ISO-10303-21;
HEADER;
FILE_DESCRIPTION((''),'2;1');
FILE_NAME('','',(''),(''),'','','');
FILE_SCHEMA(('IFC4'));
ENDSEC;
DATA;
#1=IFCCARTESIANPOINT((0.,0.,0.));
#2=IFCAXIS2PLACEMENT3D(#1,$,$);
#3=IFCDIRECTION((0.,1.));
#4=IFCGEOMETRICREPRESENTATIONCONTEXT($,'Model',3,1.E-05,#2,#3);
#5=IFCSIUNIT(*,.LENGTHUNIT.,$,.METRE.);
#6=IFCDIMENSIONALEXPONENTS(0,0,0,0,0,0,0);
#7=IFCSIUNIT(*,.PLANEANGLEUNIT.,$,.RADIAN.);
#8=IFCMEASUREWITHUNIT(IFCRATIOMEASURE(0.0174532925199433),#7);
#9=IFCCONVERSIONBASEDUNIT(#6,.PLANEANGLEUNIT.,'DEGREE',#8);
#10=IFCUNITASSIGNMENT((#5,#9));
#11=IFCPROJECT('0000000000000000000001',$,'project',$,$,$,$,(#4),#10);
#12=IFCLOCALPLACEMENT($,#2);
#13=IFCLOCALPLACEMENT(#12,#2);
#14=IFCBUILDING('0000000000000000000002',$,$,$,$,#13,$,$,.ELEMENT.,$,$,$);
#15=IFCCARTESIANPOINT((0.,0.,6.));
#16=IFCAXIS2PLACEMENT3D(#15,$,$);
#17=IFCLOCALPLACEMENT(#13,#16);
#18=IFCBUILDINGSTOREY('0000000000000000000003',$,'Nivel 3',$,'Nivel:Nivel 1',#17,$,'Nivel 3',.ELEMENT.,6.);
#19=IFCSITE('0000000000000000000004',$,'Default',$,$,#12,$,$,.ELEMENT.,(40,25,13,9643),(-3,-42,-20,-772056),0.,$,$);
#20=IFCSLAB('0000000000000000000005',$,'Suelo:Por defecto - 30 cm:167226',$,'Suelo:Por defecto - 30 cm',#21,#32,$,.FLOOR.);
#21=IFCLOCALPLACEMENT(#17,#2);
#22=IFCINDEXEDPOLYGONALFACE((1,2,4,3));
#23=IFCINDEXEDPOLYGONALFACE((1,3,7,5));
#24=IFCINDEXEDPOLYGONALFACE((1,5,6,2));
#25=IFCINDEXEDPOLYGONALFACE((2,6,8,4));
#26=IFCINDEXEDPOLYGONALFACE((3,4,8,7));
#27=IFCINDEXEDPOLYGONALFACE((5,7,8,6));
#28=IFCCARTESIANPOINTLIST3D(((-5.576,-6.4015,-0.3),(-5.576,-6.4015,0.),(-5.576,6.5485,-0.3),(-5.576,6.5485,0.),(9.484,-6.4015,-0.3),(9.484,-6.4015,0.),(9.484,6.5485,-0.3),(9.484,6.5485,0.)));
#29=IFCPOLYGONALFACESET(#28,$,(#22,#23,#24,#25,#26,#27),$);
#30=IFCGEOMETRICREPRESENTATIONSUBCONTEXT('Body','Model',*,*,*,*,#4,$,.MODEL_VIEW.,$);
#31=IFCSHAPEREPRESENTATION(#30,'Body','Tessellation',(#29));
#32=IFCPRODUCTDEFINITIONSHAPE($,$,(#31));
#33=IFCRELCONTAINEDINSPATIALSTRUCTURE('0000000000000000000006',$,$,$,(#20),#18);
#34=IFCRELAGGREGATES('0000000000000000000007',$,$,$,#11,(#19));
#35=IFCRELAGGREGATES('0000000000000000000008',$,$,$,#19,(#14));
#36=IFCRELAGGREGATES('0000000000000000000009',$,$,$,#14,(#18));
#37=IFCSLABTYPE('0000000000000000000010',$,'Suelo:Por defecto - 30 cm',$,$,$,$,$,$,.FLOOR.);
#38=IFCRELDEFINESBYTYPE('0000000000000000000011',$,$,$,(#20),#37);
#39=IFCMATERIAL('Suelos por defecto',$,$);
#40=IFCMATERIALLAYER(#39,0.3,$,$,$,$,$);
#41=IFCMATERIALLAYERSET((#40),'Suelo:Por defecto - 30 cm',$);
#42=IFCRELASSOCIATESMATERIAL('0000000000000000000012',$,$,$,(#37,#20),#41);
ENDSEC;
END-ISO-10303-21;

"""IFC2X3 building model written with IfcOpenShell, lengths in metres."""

from ifc_helpers import new_model, entity, si_unit, converted_unit, direction, frame, origin, origin_2d_with_axis, place, context, subcontext, project, spatial, rectangle, extrude, material, layer, layer_set, layer_usage, type_object, element, save


model = new_model("IFC2X3")

# Units and contexts
model_context = context("Model", 3, precision=1e-05, world=origin(), true_north=direction((0.0, 1.0)))
body_context = subcontext(model_context, "Body", "Model", "MODEL_VIEW")
ifc_project = project(units=[si_unit("LENGTHUNIT", "METRE"), converted_unit("PLANEANGLEUNIT", "DEGREE", entity("IfcRatioMeasure", 0.0174532925199433), si_unit("PLANEANGLEUNIT", "RADIAN"), dimensions=[0, 0, 0, 0, 0, 0, 0])], contexts=[model_context])

# Site, building, storey
site_placement = place(None, origin())
site = spatial("IfcSite", under=ifc_project, at=site_placement, Name="Default", CompositionType="ELEMENT", RefLatitude=(40, 25, 13, 9643), RefLongitude=(-3, -42, -20, -772056), RefElevation=0.0)
building_placement = place(site_placement, origin())
building = spatial("IfcBuilding", under=site, at=building_placement, CompositionType="ELEMENT")
storey_placement = place(building_placement, frame((0.0, 0.0, 6.0)))
storey = spatial("IfcBuildingStorey", under=building, at=storey_placement, Name="Nivel 3", ObjectType="Nivel:Nivel 1", LongName="Nivel 3", CompositionType="ELEMENT", Elevation=6.0)

# Slab
ifc_material = material(Name="Suelos por defecto")
ifc_layer = layer(ifc_material, 0.3)
ifc_layer_set = layer_set([ifc_layer], Name="Suelo:Por defecto - 30 cm")
ifc_layer_usage = layer_usage(ifc_layer_set, "AXIS3", "POSITIVE", 0.0)
slab_type = type_object("IfcSlabType", Name="Suelo:Por defecto - 30 cm", PredefinedType="FLOOR", material=ifc_layer_set)
slab_placement = place(storey_placement, origin())
element("IfcSlab", 1, at=slab_placement, inside=storey, type_object=slab_type, material=ifc_layer_usage, Name="Suelo:Por defecto - 30 cm:167226", ObjectType="Suelo:Por defecto - 30 cm", PredefinedType="FLOOR", context=body_context, shape_type="SweptSolid", body=[
    extrude(rectangle(XDim=12.95, YDim=15.06, at=origin_2d_with_axis()), frame((1.954, 0.0735, 0.0), z_axis=(0.0, 0.0, -1.0), x_axis=(0.0, 1.0, 0.0)), (0.0, 0.0, 1.0), 0.3),
])

save(model, "model.ifc")
